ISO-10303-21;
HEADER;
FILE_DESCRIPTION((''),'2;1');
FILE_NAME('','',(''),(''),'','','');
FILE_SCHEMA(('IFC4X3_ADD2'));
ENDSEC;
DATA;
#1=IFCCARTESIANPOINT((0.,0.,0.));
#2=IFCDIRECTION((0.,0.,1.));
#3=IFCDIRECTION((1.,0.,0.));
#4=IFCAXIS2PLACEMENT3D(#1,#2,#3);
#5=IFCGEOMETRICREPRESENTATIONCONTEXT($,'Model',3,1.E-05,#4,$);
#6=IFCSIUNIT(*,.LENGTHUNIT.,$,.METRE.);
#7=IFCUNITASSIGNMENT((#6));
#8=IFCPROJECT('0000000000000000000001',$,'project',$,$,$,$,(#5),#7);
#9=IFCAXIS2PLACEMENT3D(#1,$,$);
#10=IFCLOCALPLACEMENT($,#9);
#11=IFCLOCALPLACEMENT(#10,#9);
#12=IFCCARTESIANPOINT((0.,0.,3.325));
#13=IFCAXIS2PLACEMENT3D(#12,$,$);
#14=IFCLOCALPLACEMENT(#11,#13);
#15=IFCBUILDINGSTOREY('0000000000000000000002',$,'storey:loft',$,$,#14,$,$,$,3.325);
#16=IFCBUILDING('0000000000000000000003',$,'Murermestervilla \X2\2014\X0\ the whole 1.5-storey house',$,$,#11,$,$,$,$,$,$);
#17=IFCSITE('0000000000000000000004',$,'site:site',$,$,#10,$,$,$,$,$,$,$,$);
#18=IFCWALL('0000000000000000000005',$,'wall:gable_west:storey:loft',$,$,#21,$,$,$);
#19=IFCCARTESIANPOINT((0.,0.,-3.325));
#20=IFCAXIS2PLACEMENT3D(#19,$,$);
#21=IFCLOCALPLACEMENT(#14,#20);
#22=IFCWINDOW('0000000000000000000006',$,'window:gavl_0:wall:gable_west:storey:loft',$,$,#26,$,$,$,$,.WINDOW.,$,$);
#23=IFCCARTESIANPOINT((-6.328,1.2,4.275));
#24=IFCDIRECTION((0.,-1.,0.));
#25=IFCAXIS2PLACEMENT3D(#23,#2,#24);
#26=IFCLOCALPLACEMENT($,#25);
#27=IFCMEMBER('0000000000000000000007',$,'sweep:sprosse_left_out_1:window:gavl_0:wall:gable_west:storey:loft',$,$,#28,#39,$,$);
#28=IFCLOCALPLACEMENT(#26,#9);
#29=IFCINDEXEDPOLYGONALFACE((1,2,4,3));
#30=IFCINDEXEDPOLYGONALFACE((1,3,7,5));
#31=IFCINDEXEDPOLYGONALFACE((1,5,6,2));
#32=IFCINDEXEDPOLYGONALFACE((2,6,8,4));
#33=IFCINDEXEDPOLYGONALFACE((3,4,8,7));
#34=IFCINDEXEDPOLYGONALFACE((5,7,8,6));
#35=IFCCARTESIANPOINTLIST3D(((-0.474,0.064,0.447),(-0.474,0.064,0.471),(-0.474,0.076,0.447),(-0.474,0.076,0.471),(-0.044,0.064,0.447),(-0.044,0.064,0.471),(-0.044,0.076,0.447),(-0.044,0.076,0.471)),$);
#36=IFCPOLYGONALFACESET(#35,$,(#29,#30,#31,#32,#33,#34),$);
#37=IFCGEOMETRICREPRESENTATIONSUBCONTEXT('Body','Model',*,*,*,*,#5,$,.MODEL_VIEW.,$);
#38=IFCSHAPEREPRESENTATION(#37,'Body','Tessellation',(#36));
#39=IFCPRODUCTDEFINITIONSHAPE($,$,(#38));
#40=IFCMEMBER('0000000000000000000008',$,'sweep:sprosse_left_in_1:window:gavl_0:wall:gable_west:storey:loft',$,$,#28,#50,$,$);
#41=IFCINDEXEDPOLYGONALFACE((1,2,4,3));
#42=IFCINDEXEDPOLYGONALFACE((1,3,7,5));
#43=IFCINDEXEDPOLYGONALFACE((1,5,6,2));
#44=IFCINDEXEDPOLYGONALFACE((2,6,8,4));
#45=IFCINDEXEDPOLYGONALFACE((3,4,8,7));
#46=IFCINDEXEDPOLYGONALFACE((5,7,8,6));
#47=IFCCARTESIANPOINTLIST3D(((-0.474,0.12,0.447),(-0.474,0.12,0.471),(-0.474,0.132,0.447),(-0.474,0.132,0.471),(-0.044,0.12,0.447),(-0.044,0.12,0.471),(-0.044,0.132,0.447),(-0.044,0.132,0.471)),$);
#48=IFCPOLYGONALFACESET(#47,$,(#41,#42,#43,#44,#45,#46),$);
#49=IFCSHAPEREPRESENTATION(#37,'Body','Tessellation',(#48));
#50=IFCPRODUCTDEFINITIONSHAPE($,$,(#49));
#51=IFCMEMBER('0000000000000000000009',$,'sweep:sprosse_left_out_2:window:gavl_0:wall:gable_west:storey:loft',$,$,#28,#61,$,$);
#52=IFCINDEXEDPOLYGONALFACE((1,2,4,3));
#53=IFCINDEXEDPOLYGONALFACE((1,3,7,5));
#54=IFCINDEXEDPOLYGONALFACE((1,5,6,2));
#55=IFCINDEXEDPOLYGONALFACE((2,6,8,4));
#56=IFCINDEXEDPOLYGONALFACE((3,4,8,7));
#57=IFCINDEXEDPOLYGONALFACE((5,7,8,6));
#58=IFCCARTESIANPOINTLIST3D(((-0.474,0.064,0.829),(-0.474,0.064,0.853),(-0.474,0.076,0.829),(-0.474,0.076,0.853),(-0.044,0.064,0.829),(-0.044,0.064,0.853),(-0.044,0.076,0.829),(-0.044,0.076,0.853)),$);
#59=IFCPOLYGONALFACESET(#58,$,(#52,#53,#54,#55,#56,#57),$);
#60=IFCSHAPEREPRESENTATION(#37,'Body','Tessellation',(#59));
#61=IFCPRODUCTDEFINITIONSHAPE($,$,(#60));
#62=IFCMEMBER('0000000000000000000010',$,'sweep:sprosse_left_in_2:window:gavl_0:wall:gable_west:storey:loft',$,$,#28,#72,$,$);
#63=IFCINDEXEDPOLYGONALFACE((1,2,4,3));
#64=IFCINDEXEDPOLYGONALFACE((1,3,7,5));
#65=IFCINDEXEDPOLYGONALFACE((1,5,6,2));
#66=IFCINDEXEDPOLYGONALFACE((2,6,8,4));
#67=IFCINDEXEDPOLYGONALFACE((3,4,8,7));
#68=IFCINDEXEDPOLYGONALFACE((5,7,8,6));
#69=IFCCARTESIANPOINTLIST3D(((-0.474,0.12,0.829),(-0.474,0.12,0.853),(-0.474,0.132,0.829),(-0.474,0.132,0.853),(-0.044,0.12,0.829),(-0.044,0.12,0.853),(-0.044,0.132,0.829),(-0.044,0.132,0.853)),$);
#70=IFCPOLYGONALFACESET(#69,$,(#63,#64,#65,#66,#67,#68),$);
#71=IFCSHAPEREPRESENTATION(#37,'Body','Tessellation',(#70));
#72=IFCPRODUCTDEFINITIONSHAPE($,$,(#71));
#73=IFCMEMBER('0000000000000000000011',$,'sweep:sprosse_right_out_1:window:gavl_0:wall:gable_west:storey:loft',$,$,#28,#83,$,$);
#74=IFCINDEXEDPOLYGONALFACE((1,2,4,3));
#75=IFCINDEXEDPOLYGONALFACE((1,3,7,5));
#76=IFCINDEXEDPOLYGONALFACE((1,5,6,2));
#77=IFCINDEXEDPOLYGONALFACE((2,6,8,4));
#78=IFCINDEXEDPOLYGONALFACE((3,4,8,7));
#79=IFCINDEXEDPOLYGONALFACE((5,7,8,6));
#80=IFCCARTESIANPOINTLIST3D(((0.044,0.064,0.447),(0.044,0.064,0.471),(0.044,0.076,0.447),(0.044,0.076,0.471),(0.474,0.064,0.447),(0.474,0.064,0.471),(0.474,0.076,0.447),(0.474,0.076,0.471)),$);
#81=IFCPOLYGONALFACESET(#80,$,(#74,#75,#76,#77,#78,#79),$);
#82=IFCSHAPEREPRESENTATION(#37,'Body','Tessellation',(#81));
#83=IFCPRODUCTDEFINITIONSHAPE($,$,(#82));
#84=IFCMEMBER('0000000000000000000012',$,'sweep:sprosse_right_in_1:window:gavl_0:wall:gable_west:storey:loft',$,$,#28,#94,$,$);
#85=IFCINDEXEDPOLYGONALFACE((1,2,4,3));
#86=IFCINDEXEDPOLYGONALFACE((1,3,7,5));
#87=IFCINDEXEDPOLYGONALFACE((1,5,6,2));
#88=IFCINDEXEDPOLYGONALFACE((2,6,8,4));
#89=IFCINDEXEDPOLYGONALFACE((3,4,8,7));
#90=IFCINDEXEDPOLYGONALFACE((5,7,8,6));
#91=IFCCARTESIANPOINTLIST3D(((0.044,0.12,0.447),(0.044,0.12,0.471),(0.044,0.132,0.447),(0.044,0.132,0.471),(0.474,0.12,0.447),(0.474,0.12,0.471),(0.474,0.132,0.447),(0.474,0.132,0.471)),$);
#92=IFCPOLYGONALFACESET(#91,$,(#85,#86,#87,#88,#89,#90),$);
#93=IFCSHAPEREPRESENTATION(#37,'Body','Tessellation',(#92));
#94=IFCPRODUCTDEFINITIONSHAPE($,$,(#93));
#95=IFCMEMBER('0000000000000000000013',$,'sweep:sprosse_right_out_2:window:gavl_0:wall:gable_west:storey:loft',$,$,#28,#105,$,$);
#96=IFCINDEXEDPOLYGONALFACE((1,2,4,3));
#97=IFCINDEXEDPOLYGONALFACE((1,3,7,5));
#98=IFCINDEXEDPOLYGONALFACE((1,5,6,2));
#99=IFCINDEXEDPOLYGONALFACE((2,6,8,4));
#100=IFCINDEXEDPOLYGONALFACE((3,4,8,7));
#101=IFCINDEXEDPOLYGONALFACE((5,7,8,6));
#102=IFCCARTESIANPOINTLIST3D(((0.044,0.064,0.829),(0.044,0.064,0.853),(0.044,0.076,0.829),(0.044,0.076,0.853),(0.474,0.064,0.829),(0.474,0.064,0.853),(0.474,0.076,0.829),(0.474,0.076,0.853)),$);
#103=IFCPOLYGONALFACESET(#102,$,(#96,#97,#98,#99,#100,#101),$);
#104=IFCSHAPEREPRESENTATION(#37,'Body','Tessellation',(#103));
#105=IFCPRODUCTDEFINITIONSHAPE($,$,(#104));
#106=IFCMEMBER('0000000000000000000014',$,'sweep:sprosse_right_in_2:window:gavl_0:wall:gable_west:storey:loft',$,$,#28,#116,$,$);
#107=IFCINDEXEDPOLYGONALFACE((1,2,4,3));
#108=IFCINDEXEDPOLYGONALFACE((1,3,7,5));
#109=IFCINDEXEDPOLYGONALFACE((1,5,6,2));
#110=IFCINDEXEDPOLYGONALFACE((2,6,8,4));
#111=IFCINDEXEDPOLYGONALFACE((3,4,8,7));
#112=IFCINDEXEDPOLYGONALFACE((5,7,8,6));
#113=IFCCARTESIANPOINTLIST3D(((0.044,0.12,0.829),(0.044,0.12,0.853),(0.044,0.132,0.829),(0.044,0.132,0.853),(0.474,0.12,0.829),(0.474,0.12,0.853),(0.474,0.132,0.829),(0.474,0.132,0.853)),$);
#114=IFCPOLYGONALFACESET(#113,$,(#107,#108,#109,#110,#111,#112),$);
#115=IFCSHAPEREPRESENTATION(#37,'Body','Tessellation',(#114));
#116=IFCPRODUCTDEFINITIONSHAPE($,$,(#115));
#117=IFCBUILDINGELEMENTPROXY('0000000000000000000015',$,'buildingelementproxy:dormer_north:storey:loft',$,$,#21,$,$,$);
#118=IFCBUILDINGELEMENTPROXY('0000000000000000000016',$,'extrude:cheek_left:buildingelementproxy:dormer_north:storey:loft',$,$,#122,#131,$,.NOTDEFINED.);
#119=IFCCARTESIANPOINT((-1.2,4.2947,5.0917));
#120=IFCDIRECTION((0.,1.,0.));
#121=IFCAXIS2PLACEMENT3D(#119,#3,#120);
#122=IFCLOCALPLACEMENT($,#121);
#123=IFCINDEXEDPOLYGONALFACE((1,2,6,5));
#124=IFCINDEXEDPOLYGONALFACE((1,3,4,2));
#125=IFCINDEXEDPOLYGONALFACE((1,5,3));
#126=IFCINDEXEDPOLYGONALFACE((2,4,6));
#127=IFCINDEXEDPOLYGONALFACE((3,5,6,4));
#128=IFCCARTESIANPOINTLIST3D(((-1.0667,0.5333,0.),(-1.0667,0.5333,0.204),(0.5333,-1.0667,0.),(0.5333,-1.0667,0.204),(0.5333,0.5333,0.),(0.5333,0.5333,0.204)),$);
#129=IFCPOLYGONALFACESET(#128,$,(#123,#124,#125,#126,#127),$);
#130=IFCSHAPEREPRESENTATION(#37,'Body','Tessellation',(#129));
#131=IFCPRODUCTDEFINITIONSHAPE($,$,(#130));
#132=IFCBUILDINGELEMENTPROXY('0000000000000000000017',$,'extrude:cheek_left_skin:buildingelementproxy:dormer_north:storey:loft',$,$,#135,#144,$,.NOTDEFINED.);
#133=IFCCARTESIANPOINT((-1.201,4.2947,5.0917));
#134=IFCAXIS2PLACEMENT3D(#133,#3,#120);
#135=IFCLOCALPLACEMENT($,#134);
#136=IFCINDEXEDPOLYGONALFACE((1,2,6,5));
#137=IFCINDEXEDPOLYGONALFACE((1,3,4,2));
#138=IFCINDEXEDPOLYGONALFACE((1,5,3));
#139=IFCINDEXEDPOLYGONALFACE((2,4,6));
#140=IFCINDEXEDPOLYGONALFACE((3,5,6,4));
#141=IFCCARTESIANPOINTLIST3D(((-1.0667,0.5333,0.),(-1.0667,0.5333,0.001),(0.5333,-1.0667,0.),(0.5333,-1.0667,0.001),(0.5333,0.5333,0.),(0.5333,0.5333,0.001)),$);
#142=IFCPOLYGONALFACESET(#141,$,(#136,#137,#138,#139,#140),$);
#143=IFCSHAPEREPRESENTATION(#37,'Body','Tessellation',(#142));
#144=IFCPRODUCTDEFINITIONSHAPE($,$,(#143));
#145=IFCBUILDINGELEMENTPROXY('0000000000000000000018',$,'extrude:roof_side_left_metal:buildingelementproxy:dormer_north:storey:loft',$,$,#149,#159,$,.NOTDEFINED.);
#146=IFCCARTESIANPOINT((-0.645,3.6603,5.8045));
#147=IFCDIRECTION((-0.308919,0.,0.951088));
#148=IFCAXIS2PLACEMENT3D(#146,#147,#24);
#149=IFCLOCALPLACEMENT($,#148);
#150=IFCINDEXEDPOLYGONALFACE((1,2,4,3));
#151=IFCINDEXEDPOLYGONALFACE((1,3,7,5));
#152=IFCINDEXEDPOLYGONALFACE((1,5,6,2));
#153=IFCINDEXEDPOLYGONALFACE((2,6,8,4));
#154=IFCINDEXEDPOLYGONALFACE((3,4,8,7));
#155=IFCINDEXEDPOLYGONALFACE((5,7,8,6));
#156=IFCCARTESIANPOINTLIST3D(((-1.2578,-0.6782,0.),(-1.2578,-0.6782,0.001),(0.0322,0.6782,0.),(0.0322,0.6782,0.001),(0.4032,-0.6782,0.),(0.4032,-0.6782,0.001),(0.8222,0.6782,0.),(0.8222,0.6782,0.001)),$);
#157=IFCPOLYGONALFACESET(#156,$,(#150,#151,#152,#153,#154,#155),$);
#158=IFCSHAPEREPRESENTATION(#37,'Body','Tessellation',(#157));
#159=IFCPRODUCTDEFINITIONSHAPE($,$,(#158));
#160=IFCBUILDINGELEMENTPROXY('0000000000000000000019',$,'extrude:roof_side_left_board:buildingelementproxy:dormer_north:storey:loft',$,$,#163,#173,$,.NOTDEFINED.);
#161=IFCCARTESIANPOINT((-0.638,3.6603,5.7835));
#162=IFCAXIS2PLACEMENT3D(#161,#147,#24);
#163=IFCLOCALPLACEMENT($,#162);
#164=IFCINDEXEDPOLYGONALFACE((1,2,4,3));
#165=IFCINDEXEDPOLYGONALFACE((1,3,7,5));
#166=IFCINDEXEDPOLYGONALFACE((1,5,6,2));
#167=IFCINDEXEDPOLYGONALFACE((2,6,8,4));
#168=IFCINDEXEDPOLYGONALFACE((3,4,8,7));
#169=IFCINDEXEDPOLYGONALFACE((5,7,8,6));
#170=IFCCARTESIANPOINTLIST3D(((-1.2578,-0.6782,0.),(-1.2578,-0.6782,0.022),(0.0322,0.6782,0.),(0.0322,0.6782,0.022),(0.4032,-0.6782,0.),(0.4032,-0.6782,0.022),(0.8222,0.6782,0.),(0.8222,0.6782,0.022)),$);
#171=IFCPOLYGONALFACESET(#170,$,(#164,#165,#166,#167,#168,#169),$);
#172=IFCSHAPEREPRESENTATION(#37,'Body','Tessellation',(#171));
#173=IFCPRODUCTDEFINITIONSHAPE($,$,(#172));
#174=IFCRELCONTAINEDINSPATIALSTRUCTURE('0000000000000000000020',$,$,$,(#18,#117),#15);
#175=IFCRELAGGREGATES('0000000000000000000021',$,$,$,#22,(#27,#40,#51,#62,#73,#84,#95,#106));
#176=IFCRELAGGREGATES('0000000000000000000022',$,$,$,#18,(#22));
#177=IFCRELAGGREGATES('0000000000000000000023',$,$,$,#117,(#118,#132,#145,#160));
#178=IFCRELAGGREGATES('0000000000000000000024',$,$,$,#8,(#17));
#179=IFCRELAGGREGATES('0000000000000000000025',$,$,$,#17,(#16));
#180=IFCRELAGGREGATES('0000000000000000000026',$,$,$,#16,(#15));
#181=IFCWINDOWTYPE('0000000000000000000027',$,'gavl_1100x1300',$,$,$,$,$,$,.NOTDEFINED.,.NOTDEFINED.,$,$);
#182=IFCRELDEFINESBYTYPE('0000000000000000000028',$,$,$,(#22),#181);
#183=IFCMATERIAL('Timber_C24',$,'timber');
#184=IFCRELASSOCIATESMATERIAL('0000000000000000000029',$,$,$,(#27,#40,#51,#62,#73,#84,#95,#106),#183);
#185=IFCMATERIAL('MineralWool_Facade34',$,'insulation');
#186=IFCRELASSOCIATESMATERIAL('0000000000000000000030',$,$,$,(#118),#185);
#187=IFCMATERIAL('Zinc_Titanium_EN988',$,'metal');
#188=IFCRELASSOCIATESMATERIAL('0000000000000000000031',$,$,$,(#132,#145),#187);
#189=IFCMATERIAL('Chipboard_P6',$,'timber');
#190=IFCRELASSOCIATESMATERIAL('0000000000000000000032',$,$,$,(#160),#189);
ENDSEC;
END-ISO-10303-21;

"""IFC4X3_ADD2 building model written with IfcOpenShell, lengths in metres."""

from ifc_helpers import new_model, si_unit, frame, origin, origin_with_axes, place, context, subcontext, project, spatial, polyline, outline, extrude, source, transform, mapped, material, type_object, element, aggregate, save


model = new_model("IFC4X3_ADD2")

# Units and contexts
model_context = context("Model", 3, precision=1e-05, world=origin_with_axes())
body_context = subcontext(model_context, "Body", "Model", "MODEL_VIEW")
ifc_project = project(units=[si_unit("LENGTHUNIT", "METRE")], contexts=[model_context])

# Site, building, storey
placement_1 = place(None, origin())
site = spatial("IfcSite", under=ifc_project, at=placement_1, Name="site:site")
building_placement = place(placement_1, origin())
building = spatial("IfcBuilding", under=site, at=building_placement, Name="Murermestervilla — the whole 1.5-storey house")
storey_placement = place(building_placement, frame((0.0, 0.0, 3.325)))
storey = spatial("IfcBuildingStorey", under=building, at=storey_placement, Name="storey:loft", Elevation=3.325)

# Wall, window, members
placement_2 = place(storey_placement, frame((0.0, 0.0, -3.325)))
wall_1 = element("IfcWall", 1, at=placement_2, inside=storey, Name="wall:gable_west:storey:loft")
window_type_1 = type_object("IfcWindowType", Name="gavl_1100x1300", PartitioningType="NOTDEFINED", PredefinedType="NOTDEFINED")
window_1_placement = place(None, frame((-6.328, 1.2, 4.275), z_axis=(0.0, 0.0, 1.0), x_axis=(0.0, -1.0, 0.0)))
window_1 = element("IfcWindow", 2, at=window_1_placement, type_object=window_type_1, Name="window:gavl_0:wall:gable_west:storey:loft", PredefinedType="WINDOW")
ifc_material_1 = material(Name="Timber_C24", Category="timber")
placement_3 = place(window_1_placement, origin())
shared_shape_1 = source(origin(), body_context, "Body", "SweptSolid", [
    extrude(outline(polyline([(-0.006, -0.012), (0.006, -0.012), (0.006, 0.012), (-0.006, 0.012), (-0.006, -0.012)])), frame((-0.474, 0.07, 0.459), z_axis=(1.0, 0.0, 0.0), x_axis=(0.0, 1.0, 0.0)), (0.0, 0.0, 1.0), 0.43),
])
member_1 = element("IfcMember", 3, at=placement_3, material=ifc_material_1, Name="sweep:sprosse_left_out_1:window:gavl_0:wall:gable_west:storey:loft", context=body_context, shape_type="MappedRepresentation", body=[
    mapped(shared_shape_1, transform((0.0, 0.0, 0.0))),
])
shared_shape_2 = source(origin(), body_context, "Body", "SweptSolid", [
    extrude(outline(polyline([(-0.006, -0.012), (0.006, -0.012), (0.006, 0.012), (-0.006, 0.012), (-0.006, -0.012)])), frame((-0.474, 0.126, 0.459), z_axis=(1.0, 0.0, 0.0), x_axis=(0.0, 1.0, 0.0)), (0.0, 0.0, 1.0), 0.43),
])
member_2 = element("IfcMember", 4, at=placement_3, material=ifc_material_1, Name="sweep:sprosse_left_in_1:window:gavl_0:wall:gable_west:storey:loft", context=body_context, shape_type="MappedRepresentation", body=[
    mapped(shared_shape_2, transform((0.0, 0.0, 0.0))),
])
shared_shape_3 = source(origin(), body_context, "Body", "SweptSolid", [
    extrude(outline(polyline([(-0.006, -0.012), (0.006, -0.012), (0.006, 0.012), (-0.006, 0.012), (-0.006, -0.012)])), frame((-0.474, 0.07, 0.841), z_axis=(1.0, 0.0, 0.0), x_axis=(0.0, 1.0, 0.0)), (0.0, 0.0, 1.0), 0.43),
])
member_3 = element("IfcMember", 5, at=placement_3, material=ifc_material_1, Name="sweep:sprosse_left_out_2:window:gavl_0:wall:gable_west:storey:loft", context=body_context, shape_type="MappedRepresentation", body=[
    mapped(shared_shape_3, transform((0.0, 0.0, 0.0))),
])
shared_shape_4 = source(origin(), body_context, "Body", "SweptSolid", [
    extrude(outline(polyline([(-0.006, -0.012), (0.006, -0.012), (0.006, 0.012), (-0.006, 0.012), (-0.006, -0.012)])), frame((-0.474, 0.126, 0.841), z_axis=(1.0, 0.0, 0.0), x_axis=(0.0, 1.0, 0.0)), (0.0, 0.0, 1.0), 0.43),
])
member_4 = element("IfcMember", 6, at=placement_3, material=ifc_material_1, Name="sweep:sprosse_left_in_2:window:gavl_0:wall:gable_west:storey:loft", context=body_context, shape_type="MappedRepresentation", body=[
    mapped(shared_shape_4, transform((0.0, 0.0, 0.0))),
])
shared_shape_5 = source(origin(), body_context, "Body", "SweptSolid", [
    extrude(outline(polyline([(-0.006, -0.012), (0.006, -0.012), (0.006, 0.012), (-0.006, 0.012), (-0.006, -0.012)])), frame((0.044, 0.07, 0.459), z_axis=(1.0, 0.0, 0.0), x_axis=(0.0, 1.0, 0.0)), (0.0, 0.0, 1.0), 0.43),
])
member_5 = element("IfcMember", 7, at=placement_3, material=ifc_material_1, Name="sweep:sprosse_right_out_1:window:gavl_0:wall:gable_west:storey:loft", context=body_context, shape_type="MappedRepresentation", body=[
    mapped(shared_shape_5, transform((0.0, 0.0, 0.0))),
])
shared_shape_6 = source(origin(), body_context, "Body", "SweptSolid", [
    extrude(outline(polyline([(-0.006, -0.012), (0.006, -0.012), (0.006, 0.012), (-0.006, 0.012), (-0.006, -0.012)])), frame((0.044, 0.126, 0.459), z_axis=(1.0, 0.0, 0.0), x_axis=(0.0, 1.0, 0.0)), (0.0, 0.0, 1.0), 0.43),
])
member_6 = element("IfcMember", 8, at=placement_3, material=ifc_material_1, Name="sweep:sprosse_right_in_1:window:gavl_0:wall:gable_west:storey:loft", context=body_context, shape_type="MappedRepresentation", body=[
    mapped(shared_shape_6, transform((0.0, 0.0, 0.0))),
])
shared_shape_7 = source(origin(), body_context, "Body", "SweptSolid", [
    extrude(outline(polyline([(-0.006, -0.012), (0.006, -0.012), (0.006, 0.012), (-0.006, 0.012), (-0.006, -0.012)])), frame((0.044, 0.07, 0.841), z_axis=(1.0, 0.0, 0.0), x_axis=(0.0, 1.0, 0.0)), (0.0, 0.0, 1.0), 0.43),
])
member_7 = element("IfcMember", 9, at=placement_3, material=ifc_material_1, Name="sweep:sprosse_right_out_2:window:gavl_0:wall:gable_west:storey:loft", context=body_context, shape_type="MappedRepresentation", body=[
    mapped(shared_shape_7, transform((0.0, 0.0, 0.0))),
])
shared_shape_8 = source(origin(), body_context, "Body", "SweptSolid", [
    extrude(outline(polyline([(-0.006, -0.012), (0.006, -0.012), (0.006, 0.012), (-0.006, 0.012), (-0.006, -0.012)])), frame((0.044, 0.126, 0.841), z_axis=(1.0, 0.0, 0.0), x_axis=(0.0, 1.0, 0.0)), (0.0, 0.0, 1.0), 0.43),
])
member_8 = element("IfcMember", 10, at=placement_3, material=ifc_material_1, Name="sweep:sprosse_right_in_2:window:gavl_0:wall:gable_west:storey:loft", context=body_context, shape_type="MappedRepresentation", body=[
    mapped(shared_shape_8, transform((0.0, 0.0, 0.0))),
])

# Building element proxy
proxy_1 = element("IfcBuildingElementProxy", 11, at=placement_2, inside=storey, Name="buildingelementproxy:dormer_north:storey:loft")
ifc_material_2 = material(Name="Zinc_Titanium_EN988", Category="metal")
ifc_material_3 = material(Name="MineralWool_Facade34", Category="insulation")

# Building element proxies
aggregate(window_1, [member_1, member_2, member_3, member_4, member_5, member_6, member_7, member_8])
aggregate(wall_1, [window_1])
proxy_2_placement = place(None, frame((-1.2, 4.2947, 5.0917), z_axis=(1.0, 0.0, 0.0), x_axis=(0.0, 1.0, 0.0)))
proxy_2 = element("IfcBuildingElementProxy", 12, at=proxy_2_placement, material=ifc_material_3, Name="extrude:cheek_left:buildingelementproxy:dormer_north:storey:loft", PredefinedType="NOTDEFINED", context=body_context, shape_type="SweptSolid", body=[
    extrude(outline(polyline([(0.5333, -1.0667), (0.5333, 0.5333), (-1.0667, 0.5333), (0.5333, -1.0667)])), origin(), (0.0, 0.0, 1.0), 0.204),
])
proxy_3_placement = place(None, frame((-1.201, 4.2947, 5.0917), z_axis=(1.0, 0.0, 0.0), x_axis=(0.0, 1.0, 0.0)))
proxy_3 = element("IfcBuildingElementProxy", 13, at=proxy_3_placement, material=ifc_material_2, Name="extrude:cheek_left_skin:buildingelementproxy:dormer_north:storey:loft", PredefinedType="NOTDEFINED", context=body_context, shape_type="SweptSolid", body=[
    extrude(outline(polyline([(0.5333, -1.0667), (0.5333, 0.5333), (-1.0667, 0.5333), (0.5333, -1.0667)])), origin(), (0.0, 0.0, 1.0), 0.001),
])
proxy_4_placement = place(None, frame((-0.645, 3.6603, 5.8045), z_axis=(-0.308919, 0.0, 0.951088), x_axis=(0.0, -1.0, 0.0)))
proxy_4 = element("IfcBuildingElementProxy", 14, at=proxy_4_placement, material=ifc_material_2, Name="extrude:roof_side_left_metal:buildingelementproxy:dormer_north:storey:loft", PredefinedType="NOTDEFINED", context=body_context, shape_type="SweptSolid", body=[
    extrude(outline(polyline([(-1.2578, -0.6782), (0.0322, 0.6782), (0.8222, 0.6782), (0.4032, -0.6782), (-1.2578, -0.6782)])), origin(), (0.0, 0.0, 1.0), 0.001),
])
ifc_material_4 = material(Name="Chipboard_P6", Category="timber")
proxy_5_placement = place(None, frame((-0.638, 3.6603, 5.7835), z_axis=(-0.308919, 0.0, 0.951088), x_axis=(0.0, -1.0, 0.0)))
proxy_5 = element("IfcBuildingElementProxy", 15, at=proxy_5_placement, material=ifc_material_4, Name="extrude:roof_side_left_board:buildingelementproxy:dormer_north:storey:loft", PredefinedType="NOTDEFINED", context=body_context, shape_type="SweptSolid", body=[
    extrude(outline(polyline([(-1.2578, -0.6782), (0.0322, 0.6782), (0.8222, 0.6782), (0.4032, -0.6782), (-1.2578, -0.6782)])), origin(), (0.0, 0.0, 1.0), 0.022),
])
aggregate(proxy_1, [proxy_2, proxy_3, proxy_4, proxy_5])

save(model, "model.ifc")
